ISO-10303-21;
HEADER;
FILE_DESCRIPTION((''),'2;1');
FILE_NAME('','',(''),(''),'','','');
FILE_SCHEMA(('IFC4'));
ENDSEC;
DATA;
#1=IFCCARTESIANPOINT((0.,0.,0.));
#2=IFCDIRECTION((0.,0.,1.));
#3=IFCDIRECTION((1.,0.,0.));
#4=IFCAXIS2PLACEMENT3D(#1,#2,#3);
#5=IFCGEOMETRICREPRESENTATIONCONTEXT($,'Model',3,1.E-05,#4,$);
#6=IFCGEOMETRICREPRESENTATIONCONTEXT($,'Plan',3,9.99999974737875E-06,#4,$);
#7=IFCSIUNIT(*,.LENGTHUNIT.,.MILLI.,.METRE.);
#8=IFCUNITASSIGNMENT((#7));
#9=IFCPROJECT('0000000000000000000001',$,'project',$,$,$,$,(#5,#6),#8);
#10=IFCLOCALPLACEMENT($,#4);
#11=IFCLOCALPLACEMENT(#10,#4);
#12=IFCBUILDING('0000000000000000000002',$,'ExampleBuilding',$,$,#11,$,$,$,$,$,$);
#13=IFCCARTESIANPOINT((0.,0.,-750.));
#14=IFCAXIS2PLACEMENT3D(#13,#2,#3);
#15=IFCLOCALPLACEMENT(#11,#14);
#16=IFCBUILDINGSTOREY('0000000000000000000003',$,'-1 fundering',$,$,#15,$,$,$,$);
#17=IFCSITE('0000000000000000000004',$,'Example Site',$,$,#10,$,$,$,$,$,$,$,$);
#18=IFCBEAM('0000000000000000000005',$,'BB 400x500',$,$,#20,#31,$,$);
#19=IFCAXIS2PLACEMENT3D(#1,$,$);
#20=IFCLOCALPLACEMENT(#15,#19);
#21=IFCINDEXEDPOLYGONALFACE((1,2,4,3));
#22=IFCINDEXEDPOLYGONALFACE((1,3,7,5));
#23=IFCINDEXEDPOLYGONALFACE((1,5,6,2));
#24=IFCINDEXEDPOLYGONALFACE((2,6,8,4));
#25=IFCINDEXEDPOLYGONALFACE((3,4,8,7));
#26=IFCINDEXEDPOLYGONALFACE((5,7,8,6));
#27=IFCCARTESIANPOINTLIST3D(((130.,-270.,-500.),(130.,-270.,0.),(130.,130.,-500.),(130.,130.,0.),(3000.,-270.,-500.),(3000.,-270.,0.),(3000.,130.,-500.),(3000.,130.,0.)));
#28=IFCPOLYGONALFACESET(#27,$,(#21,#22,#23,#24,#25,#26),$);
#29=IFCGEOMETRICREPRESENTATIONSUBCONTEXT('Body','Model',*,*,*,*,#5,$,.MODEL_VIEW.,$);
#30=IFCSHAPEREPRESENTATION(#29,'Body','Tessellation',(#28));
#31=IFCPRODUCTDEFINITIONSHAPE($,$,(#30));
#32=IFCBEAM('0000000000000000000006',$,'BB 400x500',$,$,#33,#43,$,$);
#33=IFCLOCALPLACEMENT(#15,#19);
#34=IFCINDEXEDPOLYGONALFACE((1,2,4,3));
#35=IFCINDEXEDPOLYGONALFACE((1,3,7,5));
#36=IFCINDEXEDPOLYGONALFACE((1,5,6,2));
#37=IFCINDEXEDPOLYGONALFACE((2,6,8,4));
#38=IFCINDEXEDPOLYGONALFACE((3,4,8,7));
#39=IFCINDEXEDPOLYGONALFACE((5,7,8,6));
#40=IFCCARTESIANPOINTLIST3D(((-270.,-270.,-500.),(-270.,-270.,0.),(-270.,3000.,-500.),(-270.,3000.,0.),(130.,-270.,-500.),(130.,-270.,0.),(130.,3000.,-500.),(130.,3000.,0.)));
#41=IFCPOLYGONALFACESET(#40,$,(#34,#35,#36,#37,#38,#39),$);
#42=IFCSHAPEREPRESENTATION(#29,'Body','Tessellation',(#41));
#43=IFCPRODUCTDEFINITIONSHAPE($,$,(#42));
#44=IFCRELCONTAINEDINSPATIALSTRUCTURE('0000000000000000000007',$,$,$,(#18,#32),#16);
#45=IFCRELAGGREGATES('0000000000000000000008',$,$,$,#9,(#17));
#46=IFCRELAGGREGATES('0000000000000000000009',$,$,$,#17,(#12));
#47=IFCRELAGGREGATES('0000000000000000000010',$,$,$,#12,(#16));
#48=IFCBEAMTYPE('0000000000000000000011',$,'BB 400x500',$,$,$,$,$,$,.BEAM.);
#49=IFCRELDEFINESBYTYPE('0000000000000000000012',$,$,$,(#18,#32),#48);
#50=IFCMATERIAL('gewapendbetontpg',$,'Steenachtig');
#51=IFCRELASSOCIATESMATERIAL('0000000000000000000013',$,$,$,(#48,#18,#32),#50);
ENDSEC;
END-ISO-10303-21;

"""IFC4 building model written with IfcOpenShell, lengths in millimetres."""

from ifc_helpers import new_model, si_unit, frame, origin_with_axes, place, context, subcontext, project, spatial, rectangle, extrude, material, material_profile, profile_set, profile_usage, type_object, element, save


model = new_model("IFC4")

# Units and contexts
model_context = context("Model", 3, precision=1e-05, world=origin_with_axes())
plan_context = context("Plan", 3, precision=9.99999974737875e-06, world=origin_with_axes())
body_context = subcontext(model_context, "Body", "Model", "MODEL_VIEW")
ifc_project = project(units=[si_unit("LENGTHUNIT", "METRE", prefix="MILLI")], contexts=[model_context, plan_context])

# Site, building, storey
site_placement = place(None, frame((0.0, 0.0, 0.0), z_axis=(0.0, 0.0, 1.0), x_axis=(1.0, 0.0, 0.0)))
site = spatial("IfcSite", under=ifc_project, at=site_placement, Name="Example Site")
building_placement = place(site_placement, frame((0.0, 0.0, 0.0), z_axis=(0.0, 0.0, 1.0), x_axis=(1.0, 0.0, 0.0)))
building = spatial("IfcBuilding", under=site, at=building_placement, Name="ExampleBuilding")
storey_placement = place(building_placement, frame((0.0, 0.0, -750.0), z_axis=(0.0, 0.0, 1.0), x_axis=(1.0, 0.0, 0.0)))
storey = spatial("IfcBuildingStorey", under=building, at=storey_placement, Name="-1 fundering")

# Beams
ifc_material = material(Name="gewapendbetontpg", Category="Steenachtig")
ifc_material_profile = material_profile(ifc_material, rectangle(XDim=400.0, YDim=500.0))
ifc_profile_set = profile_set([ifc_material_profile], Name="gewapendbetontpg")
ifc_profile_usage_1 = profile_usage(ifc_profile_set, cardinal=5)
beam_type = type_object("IfcBeamType", Name="BB 400x500", PredefinedType="BEAM", material=ifc_profile_set)
beam_1_placement = place(storey_placement, frame((130.0, -70.0, -250.0), z_axis=(1.0, 0.0, 0.0), x_axis=(0.0, 1.0, 0.0)))
element("IfcBeam", 1, at=beam_1_placement, inside=storey, type_object=beam_type, material=ifc_profile_usage_1, Name="BB 400x500", context=body_context, shape_type="SweptSolid", body=[
    extrude(rectangle(XDim=400.0, YDim=500.0), origin_with_axes(), (0.0, 0.0, 1.0), 2870.0),
])
ifc_profile_usage_2 = profile_usage(ifc_profile_set, cardinal=5)
beam_2_placement = place(storey_placement, frame((-70.0, -270.0, -250.0), z_axis=(0.0, 1.0, 0.0), x_axis=(-1.0, 0.0, 0.0)))
element("IfcBeam", 2, at=beam_2_placement, inside=storey, type_object=beam_type, material=ifc_profile_usage_2, Name="BB 400x500", context=body_context, shape_type="SweptSolid", body=[
    extrude(rectangle(XDim=400.0, YDim=500.0), origin_with_axes(), (0.0, 0.0, 1.0), 3270.0),
])

save(model, "model.ifc")
